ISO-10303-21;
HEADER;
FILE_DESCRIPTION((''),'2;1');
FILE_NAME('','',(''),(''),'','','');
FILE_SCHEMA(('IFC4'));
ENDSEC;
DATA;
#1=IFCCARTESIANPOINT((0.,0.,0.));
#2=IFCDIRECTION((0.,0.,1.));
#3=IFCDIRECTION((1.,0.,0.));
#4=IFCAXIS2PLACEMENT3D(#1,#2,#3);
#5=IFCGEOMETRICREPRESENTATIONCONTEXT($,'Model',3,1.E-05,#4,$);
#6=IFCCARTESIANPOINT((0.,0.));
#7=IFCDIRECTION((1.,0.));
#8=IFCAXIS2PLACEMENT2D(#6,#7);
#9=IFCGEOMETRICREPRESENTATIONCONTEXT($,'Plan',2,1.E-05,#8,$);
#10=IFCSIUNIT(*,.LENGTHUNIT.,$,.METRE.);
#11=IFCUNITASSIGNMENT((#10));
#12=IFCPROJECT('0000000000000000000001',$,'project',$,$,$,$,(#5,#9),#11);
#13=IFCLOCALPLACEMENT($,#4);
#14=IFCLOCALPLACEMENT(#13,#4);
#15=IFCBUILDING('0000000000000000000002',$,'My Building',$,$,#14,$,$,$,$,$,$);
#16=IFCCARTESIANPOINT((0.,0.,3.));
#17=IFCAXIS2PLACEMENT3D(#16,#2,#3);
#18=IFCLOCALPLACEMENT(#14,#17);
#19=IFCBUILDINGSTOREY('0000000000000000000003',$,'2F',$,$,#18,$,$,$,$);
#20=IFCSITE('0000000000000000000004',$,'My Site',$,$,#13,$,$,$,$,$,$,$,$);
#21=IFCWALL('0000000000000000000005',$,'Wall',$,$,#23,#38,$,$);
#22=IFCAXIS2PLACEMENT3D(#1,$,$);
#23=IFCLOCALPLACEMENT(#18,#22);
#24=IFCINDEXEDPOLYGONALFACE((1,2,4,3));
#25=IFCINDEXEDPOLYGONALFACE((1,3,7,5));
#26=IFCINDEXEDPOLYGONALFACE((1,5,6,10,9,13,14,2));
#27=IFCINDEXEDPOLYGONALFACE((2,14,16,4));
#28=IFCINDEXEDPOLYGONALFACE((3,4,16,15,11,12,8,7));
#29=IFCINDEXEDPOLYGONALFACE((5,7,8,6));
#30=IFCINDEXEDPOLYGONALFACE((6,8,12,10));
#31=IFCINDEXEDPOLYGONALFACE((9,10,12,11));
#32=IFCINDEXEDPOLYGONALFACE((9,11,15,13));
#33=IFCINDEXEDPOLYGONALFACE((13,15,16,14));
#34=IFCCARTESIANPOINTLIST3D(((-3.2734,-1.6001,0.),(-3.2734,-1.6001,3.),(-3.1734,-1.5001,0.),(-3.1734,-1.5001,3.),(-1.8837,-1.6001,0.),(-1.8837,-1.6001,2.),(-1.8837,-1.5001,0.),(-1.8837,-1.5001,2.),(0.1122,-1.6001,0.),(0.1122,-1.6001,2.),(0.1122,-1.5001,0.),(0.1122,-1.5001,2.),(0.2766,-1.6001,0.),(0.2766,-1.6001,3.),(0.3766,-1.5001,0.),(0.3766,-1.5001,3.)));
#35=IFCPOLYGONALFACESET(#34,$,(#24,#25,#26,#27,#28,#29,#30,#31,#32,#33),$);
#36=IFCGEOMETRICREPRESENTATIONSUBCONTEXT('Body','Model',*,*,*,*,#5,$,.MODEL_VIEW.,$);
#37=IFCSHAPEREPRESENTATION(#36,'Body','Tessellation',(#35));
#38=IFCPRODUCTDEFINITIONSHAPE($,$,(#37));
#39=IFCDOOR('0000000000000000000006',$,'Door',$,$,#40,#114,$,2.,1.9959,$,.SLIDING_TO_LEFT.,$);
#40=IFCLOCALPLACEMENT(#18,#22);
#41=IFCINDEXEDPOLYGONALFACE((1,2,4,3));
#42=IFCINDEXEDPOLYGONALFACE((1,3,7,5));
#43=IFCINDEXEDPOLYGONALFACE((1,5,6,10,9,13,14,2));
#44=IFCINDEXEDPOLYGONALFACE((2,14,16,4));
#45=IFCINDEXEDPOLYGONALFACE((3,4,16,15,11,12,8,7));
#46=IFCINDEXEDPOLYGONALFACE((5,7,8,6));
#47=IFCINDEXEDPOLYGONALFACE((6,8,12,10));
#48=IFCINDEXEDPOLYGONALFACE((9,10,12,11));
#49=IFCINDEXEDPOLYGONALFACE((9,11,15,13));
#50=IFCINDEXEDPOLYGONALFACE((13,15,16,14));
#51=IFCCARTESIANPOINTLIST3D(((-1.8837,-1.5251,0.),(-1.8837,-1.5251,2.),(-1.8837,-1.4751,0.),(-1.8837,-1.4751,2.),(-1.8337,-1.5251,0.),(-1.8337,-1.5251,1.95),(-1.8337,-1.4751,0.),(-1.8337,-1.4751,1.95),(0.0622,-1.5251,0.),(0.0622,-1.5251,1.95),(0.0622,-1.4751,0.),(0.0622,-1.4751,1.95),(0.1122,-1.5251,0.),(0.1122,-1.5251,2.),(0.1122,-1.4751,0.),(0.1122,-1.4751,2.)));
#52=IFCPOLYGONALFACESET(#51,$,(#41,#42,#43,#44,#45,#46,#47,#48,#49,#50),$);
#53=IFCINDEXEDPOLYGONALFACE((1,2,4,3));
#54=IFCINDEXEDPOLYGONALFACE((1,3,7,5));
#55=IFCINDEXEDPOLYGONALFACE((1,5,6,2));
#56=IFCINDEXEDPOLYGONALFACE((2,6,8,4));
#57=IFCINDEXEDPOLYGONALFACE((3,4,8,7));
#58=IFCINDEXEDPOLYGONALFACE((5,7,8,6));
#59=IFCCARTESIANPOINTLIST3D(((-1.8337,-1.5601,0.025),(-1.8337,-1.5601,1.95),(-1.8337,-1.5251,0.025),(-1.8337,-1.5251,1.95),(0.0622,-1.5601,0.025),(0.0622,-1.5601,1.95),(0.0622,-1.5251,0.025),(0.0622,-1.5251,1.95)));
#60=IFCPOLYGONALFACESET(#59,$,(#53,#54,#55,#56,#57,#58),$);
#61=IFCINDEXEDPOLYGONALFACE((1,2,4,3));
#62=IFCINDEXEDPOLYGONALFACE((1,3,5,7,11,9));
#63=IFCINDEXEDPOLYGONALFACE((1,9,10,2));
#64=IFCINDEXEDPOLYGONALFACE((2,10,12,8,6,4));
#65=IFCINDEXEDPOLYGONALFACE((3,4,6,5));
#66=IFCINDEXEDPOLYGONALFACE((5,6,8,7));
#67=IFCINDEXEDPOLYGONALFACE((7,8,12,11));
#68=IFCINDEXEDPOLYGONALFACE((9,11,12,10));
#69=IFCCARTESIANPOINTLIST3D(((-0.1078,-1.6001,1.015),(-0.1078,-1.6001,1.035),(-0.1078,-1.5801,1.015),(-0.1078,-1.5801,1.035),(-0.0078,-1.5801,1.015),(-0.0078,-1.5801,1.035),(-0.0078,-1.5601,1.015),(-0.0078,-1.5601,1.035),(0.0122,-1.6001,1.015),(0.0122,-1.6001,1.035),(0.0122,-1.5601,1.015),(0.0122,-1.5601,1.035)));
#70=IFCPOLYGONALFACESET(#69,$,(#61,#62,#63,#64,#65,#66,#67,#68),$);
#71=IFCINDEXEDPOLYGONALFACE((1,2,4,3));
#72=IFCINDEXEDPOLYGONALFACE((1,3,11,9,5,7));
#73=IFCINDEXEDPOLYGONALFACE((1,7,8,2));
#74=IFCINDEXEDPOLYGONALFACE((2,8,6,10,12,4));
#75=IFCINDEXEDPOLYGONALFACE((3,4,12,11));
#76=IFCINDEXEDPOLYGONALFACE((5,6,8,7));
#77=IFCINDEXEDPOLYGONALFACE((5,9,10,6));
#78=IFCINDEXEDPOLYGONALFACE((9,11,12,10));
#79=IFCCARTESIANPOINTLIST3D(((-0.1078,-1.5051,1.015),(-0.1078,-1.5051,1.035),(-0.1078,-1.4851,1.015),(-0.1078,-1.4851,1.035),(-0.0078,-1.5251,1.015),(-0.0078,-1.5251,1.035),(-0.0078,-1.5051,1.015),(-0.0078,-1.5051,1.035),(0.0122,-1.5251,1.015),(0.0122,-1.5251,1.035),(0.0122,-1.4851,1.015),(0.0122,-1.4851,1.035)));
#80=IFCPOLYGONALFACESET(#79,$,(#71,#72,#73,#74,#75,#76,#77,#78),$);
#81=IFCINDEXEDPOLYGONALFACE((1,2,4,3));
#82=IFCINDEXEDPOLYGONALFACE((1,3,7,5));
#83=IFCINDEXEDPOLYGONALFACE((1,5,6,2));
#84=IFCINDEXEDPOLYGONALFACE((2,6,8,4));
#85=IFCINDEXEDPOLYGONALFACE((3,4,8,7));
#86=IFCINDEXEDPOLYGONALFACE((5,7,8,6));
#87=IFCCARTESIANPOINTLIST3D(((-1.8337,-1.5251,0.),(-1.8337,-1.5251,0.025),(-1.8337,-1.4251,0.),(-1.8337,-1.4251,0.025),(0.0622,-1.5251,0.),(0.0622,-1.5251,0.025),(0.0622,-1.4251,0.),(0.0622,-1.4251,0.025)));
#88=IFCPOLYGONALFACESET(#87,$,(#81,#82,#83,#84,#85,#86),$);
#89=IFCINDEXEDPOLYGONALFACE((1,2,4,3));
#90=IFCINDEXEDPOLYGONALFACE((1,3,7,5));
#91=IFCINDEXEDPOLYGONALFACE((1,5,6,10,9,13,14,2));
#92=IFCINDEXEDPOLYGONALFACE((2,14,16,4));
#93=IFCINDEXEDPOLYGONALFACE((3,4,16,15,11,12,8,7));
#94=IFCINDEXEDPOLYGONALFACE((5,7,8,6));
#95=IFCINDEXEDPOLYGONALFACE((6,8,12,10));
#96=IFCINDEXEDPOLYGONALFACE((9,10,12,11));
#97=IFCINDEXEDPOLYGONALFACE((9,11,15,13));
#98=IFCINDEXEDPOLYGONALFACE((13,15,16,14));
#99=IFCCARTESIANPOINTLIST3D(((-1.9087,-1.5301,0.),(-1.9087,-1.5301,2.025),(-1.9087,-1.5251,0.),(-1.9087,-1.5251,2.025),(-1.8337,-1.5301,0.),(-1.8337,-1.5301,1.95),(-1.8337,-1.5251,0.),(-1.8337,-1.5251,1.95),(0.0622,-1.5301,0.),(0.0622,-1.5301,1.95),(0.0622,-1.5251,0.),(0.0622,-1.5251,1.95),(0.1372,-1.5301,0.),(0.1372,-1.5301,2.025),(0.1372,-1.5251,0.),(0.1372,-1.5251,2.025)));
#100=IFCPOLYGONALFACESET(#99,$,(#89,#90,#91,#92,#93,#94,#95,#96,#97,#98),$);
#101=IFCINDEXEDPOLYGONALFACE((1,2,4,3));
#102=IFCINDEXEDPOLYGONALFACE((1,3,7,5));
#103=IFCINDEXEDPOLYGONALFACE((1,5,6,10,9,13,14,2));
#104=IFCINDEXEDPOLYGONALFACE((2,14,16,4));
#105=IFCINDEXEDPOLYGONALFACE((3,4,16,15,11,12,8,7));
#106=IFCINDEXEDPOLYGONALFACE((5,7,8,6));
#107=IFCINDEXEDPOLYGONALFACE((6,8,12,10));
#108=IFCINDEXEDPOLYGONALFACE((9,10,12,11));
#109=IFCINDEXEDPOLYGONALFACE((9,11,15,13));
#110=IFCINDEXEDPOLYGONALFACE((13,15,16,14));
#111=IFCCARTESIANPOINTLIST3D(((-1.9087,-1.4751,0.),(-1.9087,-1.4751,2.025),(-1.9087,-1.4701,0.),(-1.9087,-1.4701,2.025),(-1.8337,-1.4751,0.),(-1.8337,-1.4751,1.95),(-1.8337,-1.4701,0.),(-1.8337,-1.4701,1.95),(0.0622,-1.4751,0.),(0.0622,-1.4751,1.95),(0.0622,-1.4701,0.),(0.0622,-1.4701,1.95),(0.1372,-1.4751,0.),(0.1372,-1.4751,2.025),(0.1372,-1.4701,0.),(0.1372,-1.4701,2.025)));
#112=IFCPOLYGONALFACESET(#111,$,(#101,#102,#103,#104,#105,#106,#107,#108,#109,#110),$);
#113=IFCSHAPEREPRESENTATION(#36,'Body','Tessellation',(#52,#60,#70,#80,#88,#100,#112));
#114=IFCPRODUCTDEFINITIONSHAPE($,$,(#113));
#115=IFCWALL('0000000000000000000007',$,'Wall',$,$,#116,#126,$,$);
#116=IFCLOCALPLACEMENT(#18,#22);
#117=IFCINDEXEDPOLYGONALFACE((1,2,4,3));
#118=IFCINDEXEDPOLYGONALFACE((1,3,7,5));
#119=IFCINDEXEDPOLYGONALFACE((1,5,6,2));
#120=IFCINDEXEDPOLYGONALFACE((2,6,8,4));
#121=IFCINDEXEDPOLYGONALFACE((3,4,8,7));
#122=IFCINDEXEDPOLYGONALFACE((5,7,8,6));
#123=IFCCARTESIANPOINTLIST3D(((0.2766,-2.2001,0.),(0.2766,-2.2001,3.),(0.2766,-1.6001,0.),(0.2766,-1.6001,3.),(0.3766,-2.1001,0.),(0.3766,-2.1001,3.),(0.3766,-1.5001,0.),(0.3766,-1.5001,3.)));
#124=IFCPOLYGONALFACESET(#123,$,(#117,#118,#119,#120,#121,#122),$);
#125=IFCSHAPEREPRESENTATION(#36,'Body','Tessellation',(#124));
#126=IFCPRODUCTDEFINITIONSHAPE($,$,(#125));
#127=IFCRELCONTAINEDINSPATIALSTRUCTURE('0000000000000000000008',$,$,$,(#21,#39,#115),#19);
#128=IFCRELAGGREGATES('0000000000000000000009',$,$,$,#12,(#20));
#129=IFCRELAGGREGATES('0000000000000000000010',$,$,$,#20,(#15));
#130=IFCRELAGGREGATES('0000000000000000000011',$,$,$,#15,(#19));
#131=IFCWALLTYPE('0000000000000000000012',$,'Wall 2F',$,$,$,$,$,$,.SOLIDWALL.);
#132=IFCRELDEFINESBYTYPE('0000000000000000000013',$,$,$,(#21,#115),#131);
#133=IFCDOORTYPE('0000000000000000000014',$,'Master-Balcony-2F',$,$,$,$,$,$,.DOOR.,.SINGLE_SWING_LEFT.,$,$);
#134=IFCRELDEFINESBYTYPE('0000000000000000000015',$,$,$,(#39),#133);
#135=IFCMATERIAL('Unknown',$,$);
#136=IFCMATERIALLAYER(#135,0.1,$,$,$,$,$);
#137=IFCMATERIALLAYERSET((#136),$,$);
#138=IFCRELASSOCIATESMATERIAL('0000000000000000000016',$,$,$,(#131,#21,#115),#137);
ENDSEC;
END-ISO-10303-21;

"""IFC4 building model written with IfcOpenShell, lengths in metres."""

from ifc_helpers import new_model, entity, si_unit, frame, origin_with_axes, origin_2d_with_axis, place, context, subcontext, project, spatial, line, indexed_curve, outline, extrude, shape, source, transform, mapped, material, layer, layer_set, layer_usage, type_object, type_shapes, element, fill, save


model = new_model("IFC4")

# Units and contexts
model_context = context("Model", 3, precision=1e-05, world=origin_with_axes())
plan_context = context("Plan", 2, precision=1e-05, world=origin_2d_with_axis())
body_context_1 = subcontext(model_context, "Body", "Model", "MODEL_VIEW")
body_context_2 = subcontext(plan_context, "Body", "Plan", "PLAN_VIEW")
ifc_project = project(units=[si_unit("LENGTHUNIT", "METRE")], contexts=[model_context, plan_context])

# Site, building, storey
site_placement = place(None, origin_with_axes())
site = spatial("IfcSite", under=ifc_project, at=site_placement, Name="My Site")
building_placement = place(site_placement, origin_with_axes())
building = spatial("IfcBuilding", under=site, at=building_placement, Name="My Building")
storey_placement = place(building_placement, frame((0.0, 0.0, 3.0), z_axis=(0.0, 0.0, 1.0), x_axis=(1.0, 0.0, 0.0)))
storey = spatial("IfcBuildingStorey", under=building, at=storey_placement, Name="2F")

# Shared definitions
ifc_material = material(Name="Unknown")

# Shared definitions
ifc_layer_1 = layer(ifc_material, 0.1)
ifc_layer_set_1 = layer_set([ifc_layer_1])
wall_type = type_object("IfcWallType", Name="Wall 2F", PredefinedType="SOLIDWALL", material=ifc_layer_set_1)

# Wall, opening, door
ifc_layer_usage_1 = layer_usage(ifc_layer_set_1, "AXIS2", "POSITIVE", 0.0)
wall_1_placement = place(storey_placement, frame((-3.2734, -1.6001, 0.0), z_axis=(0.0, 0.0, 1.0), x_axis=(1.0, 0.0, 0.0)))
wall_1 = element("IfcWall", 1, at=wall_1_placement, inside=storey, type_object=wall_type, material=ifc_layer_usage_1, Name="Wall", context=body_context_1, shape_type="SweptSolid", body=[
    extrude(outline(indexed_curve([(0.0, 0.0), (0.1, 0.1), (3.65, 0.1), (3.55, 0.0)], segments=[line(1, 2, 3, 4, 1)])), origin_with_axes(), (0.0, 0.0, 1.0), 3.0),
])
shared_shape_1 = source(origin_with_axes(), body_context_1, "Body", "SweptSolid", [
    extrude(outline(indexed_curve([(0.0, 0.0), (1.9959, 0.0), (1.9959, 2.0), (0.0, 2.0)], segments=[line(1, 2, 3, 4, 1)])), frame((0.0, -0.6, 0.0), z_axis=(0.0, -1.0, 0.0), x_axis=(1.0, 0.0, 0.0)), (0.0, 0.0, -1.0), 1.2),
])
opening_1_placement = place(wall_1_placement, frame((1.3897, 0.075, 0.0), z_axis=(0.0, 0.0, 1.0), x_axis=(1.0, 0.0, 0.0)))
opening_1 = element("IfcOpeningElement", 2, at=opening_1_placement, cuts=wall_1, PredefinedType="OPENING", context=body_context_1, shape_type="MappedRepresentation", body=[
    mapped(shared_shape_1, transform((0.0, 0.0, 0.0), x_axis=(1.0, 0.0, 0.0), y_axis=(0.0, 1.0, 0.0), z_axis=(0.0, 0.0, 1.0), scale=1.0)),
])
door_type_1 = type_object("IfcDoorType", Name="Master-Balcony-2F", OperationType="SINGLE_SWING_LEFT", PredefinedType="DOOR")
shared_shape_2 = source(origin_with_axes(), body_context_1, "Body", "SweptSolid", [
    extrude(outline(indexed_curve([(0.0, 0.0), (0.0, 2.0), (1.9959, 2.0), (1.9959, 0.0), (1.9459, 0.0), (1.9459, 1.95), (0.05, 1.95), (0.05, 0.0)], segments=[line(1, 2, 3, 4, 5, 6, 7, 8, 1)])), frame((0.0, 0.0, 0.0), z_axis=(0.0, -1.0, 0.0), x_axis=(1.0, 0.0, 0.0)), (0.0, 0.0, -1.0), 0.05),
    extrude(outline(indexed_curve([(0.0, 0.0), (1.8959, 0.0), (1.8959, 0.035), (0.0, 0.035)], segments=[line(1, 2, 3, 4, 1)])), frame((0.05, -0.035, 0.025), z_axis=(0.0, 0.0, 1.0), x_axis=(1.0, 0.0, 0.0)), (0.0, 0.0, 1.0), 1.925),
    extrude(outline(indexed_curve([(0.0, 0.0), (0.0, -0.04), (-0.12, -0.04), (-0.12, -0.02), (-0.02, -0.02), (-0.02, 0.0)], segments=[line(1, 2, 3, 4, 5, 6, 1)])), frame((1.8959, -0.035, 1.015), z_axis=(0.0, 0.0, 1.0), x_axis=(1.0, 0.0, 0.0)), (0.0, 0.0, 1.0), 0.02),
    extrude(outline(indexed_curve([(0.0, 0.0), (0.0, 0.04), (-0.12, 0.04), (-0.12, 0.02), (-0.02, 0.02), (-0.02, 0.0)], segments=[line(1, 2, 3, 4, 5, 6, 1)])), frame((1.8959, 0.0, 1.015), z_axis=(0.0, 0.0, 1.0), x_axis=(1.0, 0.0, 0.0)), (0.0, 0.0, 1.0), 0.02),
    extrude(outline(indexed_curve([(0.0, 0.0), (1.8959, 0.0), (1.8959, 0.1), (0.0, 0.1)], segments=[line(1, 2, 3, 4, 1)])), frame((0.05, 0.0, 0.0), z_axis=(0.0, 0.0, 1.0), x_axis=(1.0, 0.0, 0.0)), (0.0, 0.0, 1.0), 0.025),
    extrude(outline(indexed_curve([(0.0, 0.0), (0.0, 2.025), (2.0459, 2.025), (2.0459, 0.0), (1.9709, 0.0), (1.9709, 1.95), (0.075, 1.95), (0.075, 0.0)], segments=[line(1, 2, 3, 4, 5, 6, 7, 8, 1)])), frame((-0.025, -0.005, 0.0), z_axis=(0.0, -1.0, 0.0), x_axis=(1.0, 0.0, 0.0)), (0.0, 0.0, -1.0), 0.005),
    extrude(outline(indexed_curve([(0.0, 0.0), (0.0, 2.025), (2.0459, 2.025), (2.0459, 0.0), (1.9709, 0.0), (1.9709, 1.95), (0.075, 1.95), (0.075, 0.0)], segments=[line(1, 2, 3, 4, 5, 6, 7, 8, 1)])), frame((-0.025, 0.05, 0.0), z_axis=(0.0, -1.0, 0.0), x_axis=(1.0, 0.0, 0.0)), (0.0, 0.0, -1.0), 0.005),
])
shared_shape_3 = source(origin_with_axes(), body_context_2, "Body", "Curve2D", [
    entity("IfcIndexedPolyCurve", entity("IfcCartesianPointList2D", [[0.0, 0.0], [0.05, 0.0], [0.05, 0.05], [0.0, 0.05]]), [entity("IfcLineIndex", [1, 2, 3, 4, 1])]),
    entity("IfcIndexedPolyCurve", entity("IfcCartesianPointList2D", [[1.9959, 0.0], [1.9459, 0.0], [1.9459, 0.05], [1.9959, 0.05]]), [entity("IfcLineIndex", [1, 2, 3, 4, 1])]),
    entity("IfcIndexedPolyCurve", entity("IfcCartesianPointList2D", [[-0.8979, -0.035], [0.9979, -0.035], [0.9979, 0.0], [-0.8979, 0.0]]), [entity("IfcLineIndex", [1, 2, 3, 4, 1])]),
])
type_shapes(door_type_1, [shared_shape_2, shared_shape_3])
door_1_placement = place(opening_1_placement, frame((0.0, 0.0, 0.0), z_axis=(0.0, 0.0, 1.0), x_axis=(1.0, 0.0, 0.0)))
door_1 = element("IfcDoor", 3, at=door_1_placement, inside=storey, type_object=door_type_1, Name="Door", OperationType="SLIDING_TO_LEFT", OverallHeight=2.0, OverallWidth=1.9959, shapes=[
    shape(body_context_1, "Body", "MappedRepresentation", [mapped(shared_shape_2, transform((0.0, 0.0, 0.0), x_axis=(1.0, 0.0, 0.0), y_axis=(0.0, 1.0, 0.0), z_axis=(0.0, 0.0, 1.0), scale=1.0))]),
    shape(body_context_2, "Body", "MappedRepresentation", [mapped(shared_shape_3, transform((0.0, 0.0, 0.0), x_axis=(1.0, 0.0, 0.0), y_axis=(0.0, 1.0, 0.0), z_axis=(0.0, 0.0, 1.0), scale=1.0))]),
])
fill(opening_1, door_1)

# Wall
ifc_layer_usage_2 = layer_usage(ifc_layer_set_1, "AXIS2", "POSITIVE", 0.0)
wall_2_placement = place(storey_placement, frame((0.2766, -1.6001, 0.0), z_axis=(0.0, 0.0, 1.0), x_axis=(0.0, -1.0, 0.0)))
element("IfcWall", 4, at=wall_2_placement, inside=storey, type_object=wall_type, material=ifc_layer_usage_2, Name="Wall", context=body_context_1, shape_type="SweptSolid", body=[
    extrude(outline(indexed_curve([(0.0, 0.0), (-0.1, 0.1), (0.5, 0.1), (0.6, 0.0)], segments=[line(1, 2, 3, 4, 1)])), origin_with_axes(), (0.0, 0.0, 1.0), 3.0),
])

save(model, "model.ifc")
